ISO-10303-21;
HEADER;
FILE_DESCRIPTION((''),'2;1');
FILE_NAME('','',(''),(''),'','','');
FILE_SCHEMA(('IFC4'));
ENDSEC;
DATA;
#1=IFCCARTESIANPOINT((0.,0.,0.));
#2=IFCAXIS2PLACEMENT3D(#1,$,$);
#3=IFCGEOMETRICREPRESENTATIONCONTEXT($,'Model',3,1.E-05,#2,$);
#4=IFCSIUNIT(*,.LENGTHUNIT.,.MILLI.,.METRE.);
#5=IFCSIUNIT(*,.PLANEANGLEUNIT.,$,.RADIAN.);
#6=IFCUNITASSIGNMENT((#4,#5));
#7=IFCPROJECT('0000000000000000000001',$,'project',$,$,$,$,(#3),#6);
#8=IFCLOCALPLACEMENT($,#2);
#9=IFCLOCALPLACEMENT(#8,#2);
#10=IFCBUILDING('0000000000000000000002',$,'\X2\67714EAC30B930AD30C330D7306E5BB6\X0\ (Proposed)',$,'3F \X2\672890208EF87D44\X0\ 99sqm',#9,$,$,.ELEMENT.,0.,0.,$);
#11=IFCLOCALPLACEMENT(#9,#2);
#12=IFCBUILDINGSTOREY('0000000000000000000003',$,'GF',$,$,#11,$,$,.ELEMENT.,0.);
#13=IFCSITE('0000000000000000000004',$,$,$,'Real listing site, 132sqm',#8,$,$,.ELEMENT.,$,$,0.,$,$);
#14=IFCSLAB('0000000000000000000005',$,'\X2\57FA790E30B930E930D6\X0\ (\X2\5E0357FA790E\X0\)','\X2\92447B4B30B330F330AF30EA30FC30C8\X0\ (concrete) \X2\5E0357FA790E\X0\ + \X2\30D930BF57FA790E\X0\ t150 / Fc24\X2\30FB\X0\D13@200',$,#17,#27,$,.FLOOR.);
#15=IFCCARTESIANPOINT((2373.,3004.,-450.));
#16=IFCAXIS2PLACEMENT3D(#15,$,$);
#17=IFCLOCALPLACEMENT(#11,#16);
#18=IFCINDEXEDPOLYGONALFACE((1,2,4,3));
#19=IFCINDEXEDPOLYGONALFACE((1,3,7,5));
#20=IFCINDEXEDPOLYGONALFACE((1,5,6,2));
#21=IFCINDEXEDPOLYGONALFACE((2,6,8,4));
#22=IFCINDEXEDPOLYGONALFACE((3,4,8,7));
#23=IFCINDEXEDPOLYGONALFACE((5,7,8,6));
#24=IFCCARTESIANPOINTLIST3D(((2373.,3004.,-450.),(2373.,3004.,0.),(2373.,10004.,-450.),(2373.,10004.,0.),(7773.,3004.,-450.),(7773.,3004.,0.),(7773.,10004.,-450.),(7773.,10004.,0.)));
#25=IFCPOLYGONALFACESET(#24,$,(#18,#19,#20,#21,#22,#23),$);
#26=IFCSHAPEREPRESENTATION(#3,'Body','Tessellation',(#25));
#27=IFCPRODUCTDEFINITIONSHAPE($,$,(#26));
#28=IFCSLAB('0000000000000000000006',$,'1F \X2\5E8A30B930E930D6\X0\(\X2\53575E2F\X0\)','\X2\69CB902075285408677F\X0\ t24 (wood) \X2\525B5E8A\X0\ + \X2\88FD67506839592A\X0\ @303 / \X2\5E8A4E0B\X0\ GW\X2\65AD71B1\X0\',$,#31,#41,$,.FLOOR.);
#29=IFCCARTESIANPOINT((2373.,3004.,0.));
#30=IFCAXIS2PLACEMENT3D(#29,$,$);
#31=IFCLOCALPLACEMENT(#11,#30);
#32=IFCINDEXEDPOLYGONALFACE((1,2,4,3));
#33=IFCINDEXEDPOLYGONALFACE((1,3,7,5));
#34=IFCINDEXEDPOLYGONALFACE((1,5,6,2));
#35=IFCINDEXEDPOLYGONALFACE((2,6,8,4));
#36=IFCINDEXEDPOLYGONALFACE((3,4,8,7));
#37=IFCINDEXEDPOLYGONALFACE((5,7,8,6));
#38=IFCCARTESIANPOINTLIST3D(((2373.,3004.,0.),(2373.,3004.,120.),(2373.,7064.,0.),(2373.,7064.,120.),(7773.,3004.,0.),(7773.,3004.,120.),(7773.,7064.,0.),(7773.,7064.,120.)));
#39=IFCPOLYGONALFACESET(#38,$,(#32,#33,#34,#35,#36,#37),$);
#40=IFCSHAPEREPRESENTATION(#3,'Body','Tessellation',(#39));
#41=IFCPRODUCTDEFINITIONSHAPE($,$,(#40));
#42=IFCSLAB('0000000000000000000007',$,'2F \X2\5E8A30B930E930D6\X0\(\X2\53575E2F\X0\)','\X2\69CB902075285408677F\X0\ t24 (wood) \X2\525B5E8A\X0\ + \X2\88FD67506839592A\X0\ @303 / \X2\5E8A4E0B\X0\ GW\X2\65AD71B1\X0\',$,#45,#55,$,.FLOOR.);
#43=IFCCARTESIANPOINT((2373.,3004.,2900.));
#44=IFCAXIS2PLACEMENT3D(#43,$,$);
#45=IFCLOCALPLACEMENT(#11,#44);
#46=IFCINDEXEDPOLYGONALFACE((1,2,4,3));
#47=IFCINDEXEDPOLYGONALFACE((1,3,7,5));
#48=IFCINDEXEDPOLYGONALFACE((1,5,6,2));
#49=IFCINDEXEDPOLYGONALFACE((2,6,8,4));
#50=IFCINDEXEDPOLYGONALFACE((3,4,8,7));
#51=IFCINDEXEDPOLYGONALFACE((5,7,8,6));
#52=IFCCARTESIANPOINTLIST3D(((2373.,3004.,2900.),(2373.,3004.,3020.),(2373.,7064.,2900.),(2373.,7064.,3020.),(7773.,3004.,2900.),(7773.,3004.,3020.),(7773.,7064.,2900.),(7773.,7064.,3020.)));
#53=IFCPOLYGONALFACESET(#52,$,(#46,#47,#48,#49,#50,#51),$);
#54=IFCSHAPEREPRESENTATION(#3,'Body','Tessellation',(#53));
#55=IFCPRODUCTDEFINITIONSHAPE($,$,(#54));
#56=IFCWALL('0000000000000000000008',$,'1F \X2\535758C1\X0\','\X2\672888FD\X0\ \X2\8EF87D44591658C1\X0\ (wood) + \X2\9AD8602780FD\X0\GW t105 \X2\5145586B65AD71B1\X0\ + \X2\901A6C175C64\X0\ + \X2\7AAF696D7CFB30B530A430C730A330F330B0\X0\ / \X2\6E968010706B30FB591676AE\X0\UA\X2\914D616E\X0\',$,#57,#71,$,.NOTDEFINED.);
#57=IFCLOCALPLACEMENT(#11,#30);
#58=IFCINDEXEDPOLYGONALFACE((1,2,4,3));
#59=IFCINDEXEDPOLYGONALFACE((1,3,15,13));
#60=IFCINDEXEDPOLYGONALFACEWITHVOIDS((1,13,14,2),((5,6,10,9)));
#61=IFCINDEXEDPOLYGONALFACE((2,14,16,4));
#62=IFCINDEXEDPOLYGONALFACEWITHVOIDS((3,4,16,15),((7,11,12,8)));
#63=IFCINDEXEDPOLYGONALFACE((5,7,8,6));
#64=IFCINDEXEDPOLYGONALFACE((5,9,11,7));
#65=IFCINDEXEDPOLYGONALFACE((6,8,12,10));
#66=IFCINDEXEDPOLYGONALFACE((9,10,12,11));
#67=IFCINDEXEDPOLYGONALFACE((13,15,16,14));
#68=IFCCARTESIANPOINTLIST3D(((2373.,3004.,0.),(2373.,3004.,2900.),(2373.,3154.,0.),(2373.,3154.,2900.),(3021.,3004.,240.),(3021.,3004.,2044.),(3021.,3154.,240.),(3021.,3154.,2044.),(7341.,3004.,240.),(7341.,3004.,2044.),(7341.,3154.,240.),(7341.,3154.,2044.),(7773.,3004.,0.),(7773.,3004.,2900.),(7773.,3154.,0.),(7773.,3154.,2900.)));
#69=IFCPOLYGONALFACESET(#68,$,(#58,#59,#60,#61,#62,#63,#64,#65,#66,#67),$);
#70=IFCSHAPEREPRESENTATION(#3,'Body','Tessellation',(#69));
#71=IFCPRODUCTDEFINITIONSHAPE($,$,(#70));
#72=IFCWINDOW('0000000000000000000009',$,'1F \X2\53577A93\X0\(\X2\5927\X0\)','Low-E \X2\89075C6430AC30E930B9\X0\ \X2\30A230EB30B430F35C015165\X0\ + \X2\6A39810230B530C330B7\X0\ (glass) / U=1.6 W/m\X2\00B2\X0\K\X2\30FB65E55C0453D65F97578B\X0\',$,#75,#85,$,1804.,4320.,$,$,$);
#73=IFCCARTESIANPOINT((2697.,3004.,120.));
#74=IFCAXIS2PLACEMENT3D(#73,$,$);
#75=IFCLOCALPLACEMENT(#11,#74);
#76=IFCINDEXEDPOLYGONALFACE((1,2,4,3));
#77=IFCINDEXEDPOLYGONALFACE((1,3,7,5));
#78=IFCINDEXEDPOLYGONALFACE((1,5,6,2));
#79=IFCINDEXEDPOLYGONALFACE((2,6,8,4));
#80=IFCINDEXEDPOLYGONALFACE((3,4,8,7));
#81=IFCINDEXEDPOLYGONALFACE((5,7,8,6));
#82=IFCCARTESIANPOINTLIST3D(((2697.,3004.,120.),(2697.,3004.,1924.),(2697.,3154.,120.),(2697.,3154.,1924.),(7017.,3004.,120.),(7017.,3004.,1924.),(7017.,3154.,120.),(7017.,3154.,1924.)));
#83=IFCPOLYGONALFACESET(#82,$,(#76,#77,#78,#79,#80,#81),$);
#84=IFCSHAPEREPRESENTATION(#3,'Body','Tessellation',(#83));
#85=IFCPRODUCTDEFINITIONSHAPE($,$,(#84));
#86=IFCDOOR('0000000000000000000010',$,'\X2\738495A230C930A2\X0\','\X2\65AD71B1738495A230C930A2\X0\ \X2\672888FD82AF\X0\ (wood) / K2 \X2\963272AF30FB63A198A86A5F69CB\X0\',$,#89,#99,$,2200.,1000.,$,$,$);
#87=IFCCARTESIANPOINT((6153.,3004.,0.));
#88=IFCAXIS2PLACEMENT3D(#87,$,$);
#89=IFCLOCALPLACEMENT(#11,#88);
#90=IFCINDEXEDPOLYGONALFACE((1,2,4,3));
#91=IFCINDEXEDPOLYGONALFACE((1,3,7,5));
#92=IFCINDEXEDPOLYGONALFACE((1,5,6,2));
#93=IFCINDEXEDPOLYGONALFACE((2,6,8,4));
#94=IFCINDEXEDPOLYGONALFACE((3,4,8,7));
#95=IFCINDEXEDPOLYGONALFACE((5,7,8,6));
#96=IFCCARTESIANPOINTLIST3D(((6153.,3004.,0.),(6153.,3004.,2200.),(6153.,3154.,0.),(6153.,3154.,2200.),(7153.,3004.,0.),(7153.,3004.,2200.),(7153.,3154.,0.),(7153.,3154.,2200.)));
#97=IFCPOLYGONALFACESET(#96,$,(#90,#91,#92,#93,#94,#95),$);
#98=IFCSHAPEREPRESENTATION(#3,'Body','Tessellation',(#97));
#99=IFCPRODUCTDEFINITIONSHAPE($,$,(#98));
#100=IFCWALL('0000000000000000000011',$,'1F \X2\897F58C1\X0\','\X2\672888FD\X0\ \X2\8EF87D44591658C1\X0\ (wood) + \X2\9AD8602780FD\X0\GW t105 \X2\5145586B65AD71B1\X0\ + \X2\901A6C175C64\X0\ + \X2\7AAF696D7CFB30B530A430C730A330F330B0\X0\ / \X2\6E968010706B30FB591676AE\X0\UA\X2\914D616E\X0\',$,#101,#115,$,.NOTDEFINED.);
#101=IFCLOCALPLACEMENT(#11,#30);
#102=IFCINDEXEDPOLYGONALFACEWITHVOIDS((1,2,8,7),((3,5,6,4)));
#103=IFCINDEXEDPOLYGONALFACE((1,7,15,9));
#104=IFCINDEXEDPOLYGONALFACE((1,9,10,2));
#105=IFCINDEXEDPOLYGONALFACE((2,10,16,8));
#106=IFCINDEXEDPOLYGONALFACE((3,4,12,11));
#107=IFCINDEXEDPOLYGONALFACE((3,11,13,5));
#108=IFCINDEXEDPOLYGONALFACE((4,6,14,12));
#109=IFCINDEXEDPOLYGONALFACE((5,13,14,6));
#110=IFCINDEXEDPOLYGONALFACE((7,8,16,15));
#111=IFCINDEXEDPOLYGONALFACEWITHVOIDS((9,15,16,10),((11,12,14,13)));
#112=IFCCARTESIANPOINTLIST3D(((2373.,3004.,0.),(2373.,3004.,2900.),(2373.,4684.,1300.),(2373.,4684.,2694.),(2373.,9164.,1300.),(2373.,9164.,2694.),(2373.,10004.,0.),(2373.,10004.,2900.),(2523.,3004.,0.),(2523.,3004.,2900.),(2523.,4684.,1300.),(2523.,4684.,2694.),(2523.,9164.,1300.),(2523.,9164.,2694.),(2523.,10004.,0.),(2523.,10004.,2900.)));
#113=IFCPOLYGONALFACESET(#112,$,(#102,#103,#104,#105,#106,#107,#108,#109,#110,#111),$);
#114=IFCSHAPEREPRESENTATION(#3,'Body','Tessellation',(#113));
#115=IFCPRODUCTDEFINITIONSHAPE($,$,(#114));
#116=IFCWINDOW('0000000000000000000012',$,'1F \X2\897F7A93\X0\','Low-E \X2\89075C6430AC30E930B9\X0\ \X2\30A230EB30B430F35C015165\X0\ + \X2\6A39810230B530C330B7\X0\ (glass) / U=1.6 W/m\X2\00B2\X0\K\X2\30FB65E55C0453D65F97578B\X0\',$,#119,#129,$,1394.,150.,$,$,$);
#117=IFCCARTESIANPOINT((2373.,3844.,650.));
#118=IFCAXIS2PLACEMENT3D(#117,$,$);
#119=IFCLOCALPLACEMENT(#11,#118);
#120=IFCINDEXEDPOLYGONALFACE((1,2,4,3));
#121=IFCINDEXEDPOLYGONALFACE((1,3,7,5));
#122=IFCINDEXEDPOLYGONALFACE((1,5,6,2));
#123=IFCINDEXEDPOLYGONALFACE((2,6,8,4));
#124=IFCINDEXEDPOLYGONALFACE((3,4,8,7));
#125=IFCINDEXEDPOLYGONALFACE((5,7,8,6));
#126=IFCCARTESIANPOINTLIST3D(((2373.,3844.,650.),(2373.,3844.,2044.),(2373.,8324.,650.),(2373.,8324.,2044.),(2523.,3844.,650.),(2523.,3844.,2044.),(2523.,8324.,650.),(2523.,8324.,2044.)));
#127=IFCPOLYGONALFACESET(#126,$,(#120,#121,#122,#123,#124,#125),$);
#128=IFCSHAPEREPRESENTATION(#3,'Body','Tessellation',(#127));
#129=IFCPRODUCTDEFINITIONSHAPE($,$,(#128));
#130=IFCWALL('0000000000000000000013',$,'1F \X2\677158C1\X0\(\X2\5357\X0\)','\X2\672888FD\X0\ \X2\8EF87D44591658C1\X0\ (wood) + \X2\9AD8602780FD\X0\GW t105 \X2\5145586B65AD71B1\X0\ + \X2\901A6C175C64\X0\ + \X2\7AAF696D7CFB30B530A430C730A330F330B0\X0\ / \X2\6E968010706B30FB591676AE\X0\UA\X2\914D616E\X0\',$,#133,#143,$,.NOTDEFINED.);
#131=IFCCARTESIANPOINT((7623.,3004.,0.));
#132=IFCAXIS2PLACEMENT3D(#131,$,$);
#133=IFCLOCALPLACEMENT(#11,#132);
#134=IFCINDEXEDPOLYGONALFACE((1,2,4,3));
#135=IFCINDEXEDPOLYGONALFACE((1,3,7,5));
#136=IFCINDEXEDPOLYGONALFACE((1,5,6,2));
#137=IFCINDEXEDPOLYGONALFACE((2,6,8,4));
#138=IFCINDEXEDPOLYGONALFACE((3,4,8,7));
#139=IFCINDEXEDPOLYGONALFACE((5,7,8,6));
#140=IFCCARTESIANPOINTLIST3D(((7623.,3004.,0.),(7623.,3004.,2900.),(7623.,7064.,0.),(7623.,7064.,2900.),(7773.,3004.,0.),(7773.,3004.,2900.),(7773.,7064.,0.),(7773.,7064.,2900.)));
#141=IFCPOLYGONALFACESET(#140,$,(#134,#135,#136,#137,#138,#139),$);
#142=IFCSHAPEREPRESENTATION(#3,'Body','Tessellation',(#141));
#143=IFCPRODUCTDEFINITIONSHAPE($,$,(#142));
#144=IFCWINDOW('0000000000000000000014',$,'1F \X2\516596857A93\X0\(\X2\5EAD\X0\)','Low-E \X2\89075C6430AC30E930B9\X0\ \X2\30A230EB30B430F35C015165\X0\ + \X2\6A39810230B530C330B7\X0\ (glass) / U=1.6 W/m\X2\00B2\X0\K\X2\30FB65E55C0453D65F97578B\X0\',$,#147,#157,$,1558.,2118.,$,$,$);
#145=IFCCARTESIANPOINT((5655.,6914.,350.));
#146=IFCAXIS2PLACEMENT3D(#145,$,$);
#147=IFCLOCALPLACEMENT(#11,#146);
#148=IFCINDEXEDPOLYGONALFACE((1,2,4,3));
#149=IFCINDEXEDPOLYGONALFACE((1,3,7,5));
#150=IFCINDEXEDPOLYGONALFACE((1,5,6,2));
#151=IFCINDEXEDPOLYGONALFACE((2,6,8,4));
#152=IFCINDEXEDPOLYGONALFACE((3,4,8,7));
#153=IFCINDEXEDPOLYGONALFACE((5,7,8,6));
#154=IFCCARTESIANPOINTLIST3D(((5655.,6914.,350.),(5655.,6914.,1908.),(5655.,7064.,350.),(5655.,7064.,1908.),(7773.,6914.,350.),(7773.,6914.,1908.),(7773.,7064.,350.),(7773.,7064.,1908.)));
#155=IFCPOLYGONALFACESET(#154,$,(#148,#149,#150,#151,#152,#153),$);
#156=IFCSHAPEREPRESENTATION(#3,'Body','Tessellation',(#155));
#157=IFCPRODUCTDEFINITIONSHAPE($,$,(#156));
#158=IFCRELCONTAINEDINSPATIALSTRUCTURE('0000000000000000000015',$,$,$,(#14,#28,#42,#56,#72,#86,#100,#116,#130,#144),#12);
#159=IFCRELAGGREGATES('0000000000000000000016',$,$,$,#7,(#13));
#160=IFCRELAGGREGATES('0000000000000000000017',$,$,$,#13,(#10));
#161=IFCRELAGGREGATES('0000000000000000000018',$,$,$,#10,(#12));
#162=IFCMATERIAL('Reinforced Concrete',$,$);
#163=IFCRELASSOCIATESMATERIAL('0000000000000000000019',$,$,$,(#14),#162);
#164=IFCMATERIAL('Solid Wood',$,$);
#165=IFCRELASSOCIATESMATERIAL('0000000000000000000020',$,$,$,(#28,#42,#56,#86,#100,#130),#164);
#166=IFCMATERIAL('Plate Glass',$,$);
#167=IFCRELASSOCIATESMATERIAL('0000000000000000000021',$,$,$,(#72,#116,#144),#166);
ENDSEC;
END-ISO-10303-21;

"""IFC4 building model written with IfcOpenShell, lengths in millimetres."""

from ifc_helpers import new_model, si_unit, frame, frame_2d, origin, place, context, project, spatial, rectangle, extrude, material, element, fill, save


model = new_model("IFC4")

# Units and contexts
model_context = context("Model", 3, precision=1e-05, world=origin())
ifc_project = project(units=[si_unit("LENGTHUNIT", "METRE", prefix="MILLI"), si_unit("PLANEANGLEUNIT", "RADIAN")], contexts=[model_context])

# Site, building, storey
site_placement = place(None, origin())
site = spatial("IfcSite", under=ifc_project, at=site_placement, ObjectType="Real listing site, 132sqm", CompositionType="ELEMENT", RefElevation=0.0)
building_placement = place(site_placement, origin())
building = spatial("IfcBuilding", under=site, at=building_placement, Name="東京スキップの家 (Proposed)", ObjectType="3F 木造軸組 99sqm", CompositionType="ELEMENT", ElevationOfRefHeight=0.0, ElevationOfTerrain=0.0)
storey_placement = place(building_placement, origin())
storey = spatial("IfcBuildingStorey", under=building, at=storey_placement, Name="GF", CompositionType="ELEMENT", Elevation=0.0)

# Slabs
ifc_material_1 = material(Name="Reinforced Concrete")
slab_1_placement = place(storey_placement, frame((2373.0, 3004.0, -450.0)))
element("IfcSlab", 1, at=slab_1_placement, inside=storey, material=ifc_material_1, Name="基礎スラブ (布基礎)", Description="鉄筋コンクリート (concrete) 布基礎 + ベタ基礎 t150 / Fc24・D13@200", PredefinedType="FLOOR", context=model_context, shape_type="SweptSolid", body=[
    extrude(rectangle(XDim=5400.0, YDim=7000.0, at=frame_2d((2700.0, 3500.0))), frame((2373.0, 3004.0, -450.0)), (0.0, 0.0, 1.0), 450.0),
])
ifc_material_2 = material(Name="Solid Wood")
slab_2_placement = place(storey_placement, frame((2373.0, 3004.0, 0.0)))
element("IfcSlab", 2, at=slab_2_placement, inside=storey, material=ifc_material_2, Name="1F 床スラブ(南帯)", Description="構造用合板 t24 (wood) 剛床 + 製材根太 @303 / 床下 GW断熱", PredefinedType="FLOOR", context=model_context, shape_type="SweptSolid", body=[
    extrude(rectangle(XDim=5400.0, YDim=4060.0, at=frame_2d((2700.0, 2030.0))), frame((2373.0, 3004.0, 0.0)), (0.0, 0.0, 1.0), 120.0),
])
slab_3_placement = place(storey_placement, frame((2373.0, 3004.0, 2900.0)))
element("IfcSlab", 3, at=slab_3_placement, inside=storey, material=ifc_material_2, Name="2F 床スラブ(南帯)", Description="構造用合板 t24 (wood) 剛床 + 製材根太 @303 / 床下 GW断熱", PredefinedType="FLOOR", context=model_context, shape_type="SweptSolid", body=[
    extrude(rectangle(XDim=5400.0, YDim=4060.0, at=frame_2d((2700.0, 2030.0))), frame((2373.0, 3004.0, 2900.0)), (0.0, 0.0, 1.0), 120.0),
])

# Wall, openings, window, door
wall_1_placement = place(storey_placement, frame((2373.0, 3004.0, 0.0)))
wall_1 = element("IfcWall", 4, at=wall_1_placement, inside=storey, material=ifc_material_2, Name="1F 南壁", Description="木製 軸組外壁 (wood) + 高性能GW t105 充填断熱 + 通気層 + 窯業系サイディング / 準耐火・外皮UA配慮", PredefinedType="NOTDEFINED", context=model_context, shape_type="SweptSolid", body=[
    extrude(rectangle(XDim=5400.0, YDim=150.0, at=frame_2d((2700.0, 75.0))), frame((2373.0, 3004.0, 0.0)), (0.0, 0.0, 1.0), 2900.0),
])
opening_1_placement = place(storey_placement, frame((2697.0, 3004.0, 120.0)))
opening_1 = element("IfcOpeningElement", 5, at=opening_1_placement, cuts=wall_1, PredefinedType="NOTDEFINED", context=model_context, shape_type="SweptSolid", body=[
    extrude(rectangle(XDim=4320.0, YDim=150.0, at=frame_2d((2160.0, 75.0))), frame((2697.0, 3004.0, 120.0)), (0.0, 0.0, 1.0), 1804.0),
])
opening_2_placement = place(storey_placement, frame((6153.0, 3004.0, 0.0)))
opening_2 = element("IfcOpeningElement", 6, at=opening_2_placement, cuts=wall_1, PredefinedType="NOTDEFINED", context=model_context, shape_type="SweptSolid", body=[
    extrude(rectangle(XDim=1000.0, YDim=150.0, at=frame_2d((500.0, 75.0))), frame((6153.0, 3004.0, 0.0)), (0.0, 0.0, 1.0), 2200.0),
])
ifc_material_3 = material(Name="Plate Glass")
window_1_placement = place(storey_placement, frame((2697.0, 3004.0, 120.0)))
window_1 = element("IfcWindow", 7, at=window_1_placement, inside=storey, material=ifc_material_3, Name="1F 南窓(大)", Description="Low-E 複層ガラス アルゴン封入 + 樹脂サッシ (glass) / U=1.6 W/m²K・日射取得型", OverallHeight=1804.0, OverallWidth=4320.0, context=model_context, shape_type="SweptSolid", body=[
    extrude(rectangle(XDim=4320.0, YDim=150.0, at=frame_2d((2160.0, 75.0))), frame((2697.0, 3004.0, 120.0)), (0.0, 0.0, 1.0), 1804.0),
])
fill(opening_1, window_1)
door_placement = place(storey_placement, frame((6153.0, 3004.0, 0.0)))
door = element("IfcDoor", 8, at=door_placement, inside=storey, material=ifc_material_2, Name="玄関ドア", Description="断熱玄関ドア 木製芯 (wood) / K2 防犯・採風機構", OverallHeight=2200.0, OverallWidth=1000.0, context=model_context, shape_type="SweptSolid", body=[
    extrude(rectangle(XDim=1000.0, YDim=150.0, at=frame_2d((500.0, 75.0))), frame((6153.0, 3004.0, 0.0)), (0.0, 0.0, 1.0), 2200.0),
])
fill(opening_2, door)

# Walls, openings, windows
wall_2_placement = place(storey_placement, frame((2373.0, 3004.0, 0.0)))
wall_2 = element("IfcWall", 9, at=wall_2_placement, inside=storey, material=ifc_material_2, Name="1F 西壁", Description="木製 軸組外壁 (wood) + 高性能GW t105 充填断熱 + 通気層 + 窯業系サイディング / 準耐火・外皮UA配慮", PredefinedType="NOTDEFINED", context=model_context, shape_type="SweptSolid", body=[
    extrude(rectangle(XDim=150.0, YDim=7000.0, at=frame_2d((75.0, 3500.0))), frame((2373.0, 3004.0, 0.0)), (0.0, 0.0, 1.0), 2900.0),
])
opening_3_placement = place(storey_placement, frame((2373.0, 3844.0, 650.0)))
opening_3 = element("IfcOpeningElement", 10, at=opening_3_placement, cuts=wall_2, PredefinedType="NOTDEFINED", context=model_context, shape_type="SweptSolid", body=[
    extrude(rectangle(XDim=150.0, YDim=4480.0, at=frame_2d((75.0, 2240.0))), frame((2373.0, 3844.0, 650.0)), (0.0, 0.0, 1.0), 1394.0),
])
window_2_placement = place(storey_placement, frame((2373.0, 3844.0, 650.0)))
window_2 = element("IfcWindow", 11, at=window_2_placement, inside=storey, material=ifc_material_3, Name="1F 西窓", Description="Low-E 複層ガラス アルゴン封入 + 樹脂サッシ (glass) / U=1.6 W/m²K・日射取得型", OverallHeight=1394.0, OverallWidth=150.0, context=model_context, shape_type="SweptSolid", body=[
    extrude(rectangle(XDim=150.0, YDim=4480.0, at=frame_2d((75.0, 2240.0))), frame((2373.0, 3844.0, 650.0)), (0.0, 0.0, 1.0), 1394.0),
])
fill(opening_3, window_2)
wall_3_placement = place(storey_placement, frame((7623.0, 3004.0, 0.0)))
wall_3 = element("IfcWall", 12, at=wall_3_placement, inside=storey, material=ifc_material_2, Name="1F 東壁(南)", Description="木製 軸組外壁 (wood) + 高性能GW t105 充填断熱 + 通気層 + 窯業系サイディング / 準耐火・外皮UA配慮", PredefinedType="NOTDEFINED", context=model_context, shape_type="SweptSolid", body=[
    extrude(rectangle(XDim=150.0, YDim=4060.0, at=frame_2d((75.0, 2030.0))), frame((7623.0, 3004.0, 0.0)), (0.0, 0.0, 1.0), 2900.0),
])
opening_4_placement = place(storey_placement, frame((5655.0, 6914.0, 350.0)))
opening_4 = element("IfcOpeningElement", 13, at=opening_4_placement, cuts=wall_3, PredefinedType="NOTDEFINED", context=model_context, shape_type="SweptSolid", body=[
    extrude(rectangle(XDim=2118.0, YDim=150.0, at=frame_2d((1059.0, 75.0))), frame((5655.0, 6914.0, 350.0)), (0.0, 0.0, 1.0), 1558.0),
])
window_3_placement = place(storey_placement, frame((5655.0, 6914.0, 350.0)))
window_3 = element("IfcWindow", 14, at=window_3_placement, inside=storey, material=ifc_material_3, Name="1F 入隅窓(庭)", Description="Low-E 複層ガラス アルゴン封入 + 樹脂サッシ (glass) / U=1.6 W/m²K・日射取得型", OverallHeight=1558.0, OverallWidth=2118.0, context=model_context, shape_type="SweptSolid", body=[
    extrude(rectangle(XDim=2118.0, YDim=150.0, at=frame_2d((1059.0, 75.0))), frame((5655.0, 6914.0, 350.0)), (0.0, 0.0, 1.0), 1558.0),
])
fill(opening_4, window_3)

save(model, "model.ifc")
